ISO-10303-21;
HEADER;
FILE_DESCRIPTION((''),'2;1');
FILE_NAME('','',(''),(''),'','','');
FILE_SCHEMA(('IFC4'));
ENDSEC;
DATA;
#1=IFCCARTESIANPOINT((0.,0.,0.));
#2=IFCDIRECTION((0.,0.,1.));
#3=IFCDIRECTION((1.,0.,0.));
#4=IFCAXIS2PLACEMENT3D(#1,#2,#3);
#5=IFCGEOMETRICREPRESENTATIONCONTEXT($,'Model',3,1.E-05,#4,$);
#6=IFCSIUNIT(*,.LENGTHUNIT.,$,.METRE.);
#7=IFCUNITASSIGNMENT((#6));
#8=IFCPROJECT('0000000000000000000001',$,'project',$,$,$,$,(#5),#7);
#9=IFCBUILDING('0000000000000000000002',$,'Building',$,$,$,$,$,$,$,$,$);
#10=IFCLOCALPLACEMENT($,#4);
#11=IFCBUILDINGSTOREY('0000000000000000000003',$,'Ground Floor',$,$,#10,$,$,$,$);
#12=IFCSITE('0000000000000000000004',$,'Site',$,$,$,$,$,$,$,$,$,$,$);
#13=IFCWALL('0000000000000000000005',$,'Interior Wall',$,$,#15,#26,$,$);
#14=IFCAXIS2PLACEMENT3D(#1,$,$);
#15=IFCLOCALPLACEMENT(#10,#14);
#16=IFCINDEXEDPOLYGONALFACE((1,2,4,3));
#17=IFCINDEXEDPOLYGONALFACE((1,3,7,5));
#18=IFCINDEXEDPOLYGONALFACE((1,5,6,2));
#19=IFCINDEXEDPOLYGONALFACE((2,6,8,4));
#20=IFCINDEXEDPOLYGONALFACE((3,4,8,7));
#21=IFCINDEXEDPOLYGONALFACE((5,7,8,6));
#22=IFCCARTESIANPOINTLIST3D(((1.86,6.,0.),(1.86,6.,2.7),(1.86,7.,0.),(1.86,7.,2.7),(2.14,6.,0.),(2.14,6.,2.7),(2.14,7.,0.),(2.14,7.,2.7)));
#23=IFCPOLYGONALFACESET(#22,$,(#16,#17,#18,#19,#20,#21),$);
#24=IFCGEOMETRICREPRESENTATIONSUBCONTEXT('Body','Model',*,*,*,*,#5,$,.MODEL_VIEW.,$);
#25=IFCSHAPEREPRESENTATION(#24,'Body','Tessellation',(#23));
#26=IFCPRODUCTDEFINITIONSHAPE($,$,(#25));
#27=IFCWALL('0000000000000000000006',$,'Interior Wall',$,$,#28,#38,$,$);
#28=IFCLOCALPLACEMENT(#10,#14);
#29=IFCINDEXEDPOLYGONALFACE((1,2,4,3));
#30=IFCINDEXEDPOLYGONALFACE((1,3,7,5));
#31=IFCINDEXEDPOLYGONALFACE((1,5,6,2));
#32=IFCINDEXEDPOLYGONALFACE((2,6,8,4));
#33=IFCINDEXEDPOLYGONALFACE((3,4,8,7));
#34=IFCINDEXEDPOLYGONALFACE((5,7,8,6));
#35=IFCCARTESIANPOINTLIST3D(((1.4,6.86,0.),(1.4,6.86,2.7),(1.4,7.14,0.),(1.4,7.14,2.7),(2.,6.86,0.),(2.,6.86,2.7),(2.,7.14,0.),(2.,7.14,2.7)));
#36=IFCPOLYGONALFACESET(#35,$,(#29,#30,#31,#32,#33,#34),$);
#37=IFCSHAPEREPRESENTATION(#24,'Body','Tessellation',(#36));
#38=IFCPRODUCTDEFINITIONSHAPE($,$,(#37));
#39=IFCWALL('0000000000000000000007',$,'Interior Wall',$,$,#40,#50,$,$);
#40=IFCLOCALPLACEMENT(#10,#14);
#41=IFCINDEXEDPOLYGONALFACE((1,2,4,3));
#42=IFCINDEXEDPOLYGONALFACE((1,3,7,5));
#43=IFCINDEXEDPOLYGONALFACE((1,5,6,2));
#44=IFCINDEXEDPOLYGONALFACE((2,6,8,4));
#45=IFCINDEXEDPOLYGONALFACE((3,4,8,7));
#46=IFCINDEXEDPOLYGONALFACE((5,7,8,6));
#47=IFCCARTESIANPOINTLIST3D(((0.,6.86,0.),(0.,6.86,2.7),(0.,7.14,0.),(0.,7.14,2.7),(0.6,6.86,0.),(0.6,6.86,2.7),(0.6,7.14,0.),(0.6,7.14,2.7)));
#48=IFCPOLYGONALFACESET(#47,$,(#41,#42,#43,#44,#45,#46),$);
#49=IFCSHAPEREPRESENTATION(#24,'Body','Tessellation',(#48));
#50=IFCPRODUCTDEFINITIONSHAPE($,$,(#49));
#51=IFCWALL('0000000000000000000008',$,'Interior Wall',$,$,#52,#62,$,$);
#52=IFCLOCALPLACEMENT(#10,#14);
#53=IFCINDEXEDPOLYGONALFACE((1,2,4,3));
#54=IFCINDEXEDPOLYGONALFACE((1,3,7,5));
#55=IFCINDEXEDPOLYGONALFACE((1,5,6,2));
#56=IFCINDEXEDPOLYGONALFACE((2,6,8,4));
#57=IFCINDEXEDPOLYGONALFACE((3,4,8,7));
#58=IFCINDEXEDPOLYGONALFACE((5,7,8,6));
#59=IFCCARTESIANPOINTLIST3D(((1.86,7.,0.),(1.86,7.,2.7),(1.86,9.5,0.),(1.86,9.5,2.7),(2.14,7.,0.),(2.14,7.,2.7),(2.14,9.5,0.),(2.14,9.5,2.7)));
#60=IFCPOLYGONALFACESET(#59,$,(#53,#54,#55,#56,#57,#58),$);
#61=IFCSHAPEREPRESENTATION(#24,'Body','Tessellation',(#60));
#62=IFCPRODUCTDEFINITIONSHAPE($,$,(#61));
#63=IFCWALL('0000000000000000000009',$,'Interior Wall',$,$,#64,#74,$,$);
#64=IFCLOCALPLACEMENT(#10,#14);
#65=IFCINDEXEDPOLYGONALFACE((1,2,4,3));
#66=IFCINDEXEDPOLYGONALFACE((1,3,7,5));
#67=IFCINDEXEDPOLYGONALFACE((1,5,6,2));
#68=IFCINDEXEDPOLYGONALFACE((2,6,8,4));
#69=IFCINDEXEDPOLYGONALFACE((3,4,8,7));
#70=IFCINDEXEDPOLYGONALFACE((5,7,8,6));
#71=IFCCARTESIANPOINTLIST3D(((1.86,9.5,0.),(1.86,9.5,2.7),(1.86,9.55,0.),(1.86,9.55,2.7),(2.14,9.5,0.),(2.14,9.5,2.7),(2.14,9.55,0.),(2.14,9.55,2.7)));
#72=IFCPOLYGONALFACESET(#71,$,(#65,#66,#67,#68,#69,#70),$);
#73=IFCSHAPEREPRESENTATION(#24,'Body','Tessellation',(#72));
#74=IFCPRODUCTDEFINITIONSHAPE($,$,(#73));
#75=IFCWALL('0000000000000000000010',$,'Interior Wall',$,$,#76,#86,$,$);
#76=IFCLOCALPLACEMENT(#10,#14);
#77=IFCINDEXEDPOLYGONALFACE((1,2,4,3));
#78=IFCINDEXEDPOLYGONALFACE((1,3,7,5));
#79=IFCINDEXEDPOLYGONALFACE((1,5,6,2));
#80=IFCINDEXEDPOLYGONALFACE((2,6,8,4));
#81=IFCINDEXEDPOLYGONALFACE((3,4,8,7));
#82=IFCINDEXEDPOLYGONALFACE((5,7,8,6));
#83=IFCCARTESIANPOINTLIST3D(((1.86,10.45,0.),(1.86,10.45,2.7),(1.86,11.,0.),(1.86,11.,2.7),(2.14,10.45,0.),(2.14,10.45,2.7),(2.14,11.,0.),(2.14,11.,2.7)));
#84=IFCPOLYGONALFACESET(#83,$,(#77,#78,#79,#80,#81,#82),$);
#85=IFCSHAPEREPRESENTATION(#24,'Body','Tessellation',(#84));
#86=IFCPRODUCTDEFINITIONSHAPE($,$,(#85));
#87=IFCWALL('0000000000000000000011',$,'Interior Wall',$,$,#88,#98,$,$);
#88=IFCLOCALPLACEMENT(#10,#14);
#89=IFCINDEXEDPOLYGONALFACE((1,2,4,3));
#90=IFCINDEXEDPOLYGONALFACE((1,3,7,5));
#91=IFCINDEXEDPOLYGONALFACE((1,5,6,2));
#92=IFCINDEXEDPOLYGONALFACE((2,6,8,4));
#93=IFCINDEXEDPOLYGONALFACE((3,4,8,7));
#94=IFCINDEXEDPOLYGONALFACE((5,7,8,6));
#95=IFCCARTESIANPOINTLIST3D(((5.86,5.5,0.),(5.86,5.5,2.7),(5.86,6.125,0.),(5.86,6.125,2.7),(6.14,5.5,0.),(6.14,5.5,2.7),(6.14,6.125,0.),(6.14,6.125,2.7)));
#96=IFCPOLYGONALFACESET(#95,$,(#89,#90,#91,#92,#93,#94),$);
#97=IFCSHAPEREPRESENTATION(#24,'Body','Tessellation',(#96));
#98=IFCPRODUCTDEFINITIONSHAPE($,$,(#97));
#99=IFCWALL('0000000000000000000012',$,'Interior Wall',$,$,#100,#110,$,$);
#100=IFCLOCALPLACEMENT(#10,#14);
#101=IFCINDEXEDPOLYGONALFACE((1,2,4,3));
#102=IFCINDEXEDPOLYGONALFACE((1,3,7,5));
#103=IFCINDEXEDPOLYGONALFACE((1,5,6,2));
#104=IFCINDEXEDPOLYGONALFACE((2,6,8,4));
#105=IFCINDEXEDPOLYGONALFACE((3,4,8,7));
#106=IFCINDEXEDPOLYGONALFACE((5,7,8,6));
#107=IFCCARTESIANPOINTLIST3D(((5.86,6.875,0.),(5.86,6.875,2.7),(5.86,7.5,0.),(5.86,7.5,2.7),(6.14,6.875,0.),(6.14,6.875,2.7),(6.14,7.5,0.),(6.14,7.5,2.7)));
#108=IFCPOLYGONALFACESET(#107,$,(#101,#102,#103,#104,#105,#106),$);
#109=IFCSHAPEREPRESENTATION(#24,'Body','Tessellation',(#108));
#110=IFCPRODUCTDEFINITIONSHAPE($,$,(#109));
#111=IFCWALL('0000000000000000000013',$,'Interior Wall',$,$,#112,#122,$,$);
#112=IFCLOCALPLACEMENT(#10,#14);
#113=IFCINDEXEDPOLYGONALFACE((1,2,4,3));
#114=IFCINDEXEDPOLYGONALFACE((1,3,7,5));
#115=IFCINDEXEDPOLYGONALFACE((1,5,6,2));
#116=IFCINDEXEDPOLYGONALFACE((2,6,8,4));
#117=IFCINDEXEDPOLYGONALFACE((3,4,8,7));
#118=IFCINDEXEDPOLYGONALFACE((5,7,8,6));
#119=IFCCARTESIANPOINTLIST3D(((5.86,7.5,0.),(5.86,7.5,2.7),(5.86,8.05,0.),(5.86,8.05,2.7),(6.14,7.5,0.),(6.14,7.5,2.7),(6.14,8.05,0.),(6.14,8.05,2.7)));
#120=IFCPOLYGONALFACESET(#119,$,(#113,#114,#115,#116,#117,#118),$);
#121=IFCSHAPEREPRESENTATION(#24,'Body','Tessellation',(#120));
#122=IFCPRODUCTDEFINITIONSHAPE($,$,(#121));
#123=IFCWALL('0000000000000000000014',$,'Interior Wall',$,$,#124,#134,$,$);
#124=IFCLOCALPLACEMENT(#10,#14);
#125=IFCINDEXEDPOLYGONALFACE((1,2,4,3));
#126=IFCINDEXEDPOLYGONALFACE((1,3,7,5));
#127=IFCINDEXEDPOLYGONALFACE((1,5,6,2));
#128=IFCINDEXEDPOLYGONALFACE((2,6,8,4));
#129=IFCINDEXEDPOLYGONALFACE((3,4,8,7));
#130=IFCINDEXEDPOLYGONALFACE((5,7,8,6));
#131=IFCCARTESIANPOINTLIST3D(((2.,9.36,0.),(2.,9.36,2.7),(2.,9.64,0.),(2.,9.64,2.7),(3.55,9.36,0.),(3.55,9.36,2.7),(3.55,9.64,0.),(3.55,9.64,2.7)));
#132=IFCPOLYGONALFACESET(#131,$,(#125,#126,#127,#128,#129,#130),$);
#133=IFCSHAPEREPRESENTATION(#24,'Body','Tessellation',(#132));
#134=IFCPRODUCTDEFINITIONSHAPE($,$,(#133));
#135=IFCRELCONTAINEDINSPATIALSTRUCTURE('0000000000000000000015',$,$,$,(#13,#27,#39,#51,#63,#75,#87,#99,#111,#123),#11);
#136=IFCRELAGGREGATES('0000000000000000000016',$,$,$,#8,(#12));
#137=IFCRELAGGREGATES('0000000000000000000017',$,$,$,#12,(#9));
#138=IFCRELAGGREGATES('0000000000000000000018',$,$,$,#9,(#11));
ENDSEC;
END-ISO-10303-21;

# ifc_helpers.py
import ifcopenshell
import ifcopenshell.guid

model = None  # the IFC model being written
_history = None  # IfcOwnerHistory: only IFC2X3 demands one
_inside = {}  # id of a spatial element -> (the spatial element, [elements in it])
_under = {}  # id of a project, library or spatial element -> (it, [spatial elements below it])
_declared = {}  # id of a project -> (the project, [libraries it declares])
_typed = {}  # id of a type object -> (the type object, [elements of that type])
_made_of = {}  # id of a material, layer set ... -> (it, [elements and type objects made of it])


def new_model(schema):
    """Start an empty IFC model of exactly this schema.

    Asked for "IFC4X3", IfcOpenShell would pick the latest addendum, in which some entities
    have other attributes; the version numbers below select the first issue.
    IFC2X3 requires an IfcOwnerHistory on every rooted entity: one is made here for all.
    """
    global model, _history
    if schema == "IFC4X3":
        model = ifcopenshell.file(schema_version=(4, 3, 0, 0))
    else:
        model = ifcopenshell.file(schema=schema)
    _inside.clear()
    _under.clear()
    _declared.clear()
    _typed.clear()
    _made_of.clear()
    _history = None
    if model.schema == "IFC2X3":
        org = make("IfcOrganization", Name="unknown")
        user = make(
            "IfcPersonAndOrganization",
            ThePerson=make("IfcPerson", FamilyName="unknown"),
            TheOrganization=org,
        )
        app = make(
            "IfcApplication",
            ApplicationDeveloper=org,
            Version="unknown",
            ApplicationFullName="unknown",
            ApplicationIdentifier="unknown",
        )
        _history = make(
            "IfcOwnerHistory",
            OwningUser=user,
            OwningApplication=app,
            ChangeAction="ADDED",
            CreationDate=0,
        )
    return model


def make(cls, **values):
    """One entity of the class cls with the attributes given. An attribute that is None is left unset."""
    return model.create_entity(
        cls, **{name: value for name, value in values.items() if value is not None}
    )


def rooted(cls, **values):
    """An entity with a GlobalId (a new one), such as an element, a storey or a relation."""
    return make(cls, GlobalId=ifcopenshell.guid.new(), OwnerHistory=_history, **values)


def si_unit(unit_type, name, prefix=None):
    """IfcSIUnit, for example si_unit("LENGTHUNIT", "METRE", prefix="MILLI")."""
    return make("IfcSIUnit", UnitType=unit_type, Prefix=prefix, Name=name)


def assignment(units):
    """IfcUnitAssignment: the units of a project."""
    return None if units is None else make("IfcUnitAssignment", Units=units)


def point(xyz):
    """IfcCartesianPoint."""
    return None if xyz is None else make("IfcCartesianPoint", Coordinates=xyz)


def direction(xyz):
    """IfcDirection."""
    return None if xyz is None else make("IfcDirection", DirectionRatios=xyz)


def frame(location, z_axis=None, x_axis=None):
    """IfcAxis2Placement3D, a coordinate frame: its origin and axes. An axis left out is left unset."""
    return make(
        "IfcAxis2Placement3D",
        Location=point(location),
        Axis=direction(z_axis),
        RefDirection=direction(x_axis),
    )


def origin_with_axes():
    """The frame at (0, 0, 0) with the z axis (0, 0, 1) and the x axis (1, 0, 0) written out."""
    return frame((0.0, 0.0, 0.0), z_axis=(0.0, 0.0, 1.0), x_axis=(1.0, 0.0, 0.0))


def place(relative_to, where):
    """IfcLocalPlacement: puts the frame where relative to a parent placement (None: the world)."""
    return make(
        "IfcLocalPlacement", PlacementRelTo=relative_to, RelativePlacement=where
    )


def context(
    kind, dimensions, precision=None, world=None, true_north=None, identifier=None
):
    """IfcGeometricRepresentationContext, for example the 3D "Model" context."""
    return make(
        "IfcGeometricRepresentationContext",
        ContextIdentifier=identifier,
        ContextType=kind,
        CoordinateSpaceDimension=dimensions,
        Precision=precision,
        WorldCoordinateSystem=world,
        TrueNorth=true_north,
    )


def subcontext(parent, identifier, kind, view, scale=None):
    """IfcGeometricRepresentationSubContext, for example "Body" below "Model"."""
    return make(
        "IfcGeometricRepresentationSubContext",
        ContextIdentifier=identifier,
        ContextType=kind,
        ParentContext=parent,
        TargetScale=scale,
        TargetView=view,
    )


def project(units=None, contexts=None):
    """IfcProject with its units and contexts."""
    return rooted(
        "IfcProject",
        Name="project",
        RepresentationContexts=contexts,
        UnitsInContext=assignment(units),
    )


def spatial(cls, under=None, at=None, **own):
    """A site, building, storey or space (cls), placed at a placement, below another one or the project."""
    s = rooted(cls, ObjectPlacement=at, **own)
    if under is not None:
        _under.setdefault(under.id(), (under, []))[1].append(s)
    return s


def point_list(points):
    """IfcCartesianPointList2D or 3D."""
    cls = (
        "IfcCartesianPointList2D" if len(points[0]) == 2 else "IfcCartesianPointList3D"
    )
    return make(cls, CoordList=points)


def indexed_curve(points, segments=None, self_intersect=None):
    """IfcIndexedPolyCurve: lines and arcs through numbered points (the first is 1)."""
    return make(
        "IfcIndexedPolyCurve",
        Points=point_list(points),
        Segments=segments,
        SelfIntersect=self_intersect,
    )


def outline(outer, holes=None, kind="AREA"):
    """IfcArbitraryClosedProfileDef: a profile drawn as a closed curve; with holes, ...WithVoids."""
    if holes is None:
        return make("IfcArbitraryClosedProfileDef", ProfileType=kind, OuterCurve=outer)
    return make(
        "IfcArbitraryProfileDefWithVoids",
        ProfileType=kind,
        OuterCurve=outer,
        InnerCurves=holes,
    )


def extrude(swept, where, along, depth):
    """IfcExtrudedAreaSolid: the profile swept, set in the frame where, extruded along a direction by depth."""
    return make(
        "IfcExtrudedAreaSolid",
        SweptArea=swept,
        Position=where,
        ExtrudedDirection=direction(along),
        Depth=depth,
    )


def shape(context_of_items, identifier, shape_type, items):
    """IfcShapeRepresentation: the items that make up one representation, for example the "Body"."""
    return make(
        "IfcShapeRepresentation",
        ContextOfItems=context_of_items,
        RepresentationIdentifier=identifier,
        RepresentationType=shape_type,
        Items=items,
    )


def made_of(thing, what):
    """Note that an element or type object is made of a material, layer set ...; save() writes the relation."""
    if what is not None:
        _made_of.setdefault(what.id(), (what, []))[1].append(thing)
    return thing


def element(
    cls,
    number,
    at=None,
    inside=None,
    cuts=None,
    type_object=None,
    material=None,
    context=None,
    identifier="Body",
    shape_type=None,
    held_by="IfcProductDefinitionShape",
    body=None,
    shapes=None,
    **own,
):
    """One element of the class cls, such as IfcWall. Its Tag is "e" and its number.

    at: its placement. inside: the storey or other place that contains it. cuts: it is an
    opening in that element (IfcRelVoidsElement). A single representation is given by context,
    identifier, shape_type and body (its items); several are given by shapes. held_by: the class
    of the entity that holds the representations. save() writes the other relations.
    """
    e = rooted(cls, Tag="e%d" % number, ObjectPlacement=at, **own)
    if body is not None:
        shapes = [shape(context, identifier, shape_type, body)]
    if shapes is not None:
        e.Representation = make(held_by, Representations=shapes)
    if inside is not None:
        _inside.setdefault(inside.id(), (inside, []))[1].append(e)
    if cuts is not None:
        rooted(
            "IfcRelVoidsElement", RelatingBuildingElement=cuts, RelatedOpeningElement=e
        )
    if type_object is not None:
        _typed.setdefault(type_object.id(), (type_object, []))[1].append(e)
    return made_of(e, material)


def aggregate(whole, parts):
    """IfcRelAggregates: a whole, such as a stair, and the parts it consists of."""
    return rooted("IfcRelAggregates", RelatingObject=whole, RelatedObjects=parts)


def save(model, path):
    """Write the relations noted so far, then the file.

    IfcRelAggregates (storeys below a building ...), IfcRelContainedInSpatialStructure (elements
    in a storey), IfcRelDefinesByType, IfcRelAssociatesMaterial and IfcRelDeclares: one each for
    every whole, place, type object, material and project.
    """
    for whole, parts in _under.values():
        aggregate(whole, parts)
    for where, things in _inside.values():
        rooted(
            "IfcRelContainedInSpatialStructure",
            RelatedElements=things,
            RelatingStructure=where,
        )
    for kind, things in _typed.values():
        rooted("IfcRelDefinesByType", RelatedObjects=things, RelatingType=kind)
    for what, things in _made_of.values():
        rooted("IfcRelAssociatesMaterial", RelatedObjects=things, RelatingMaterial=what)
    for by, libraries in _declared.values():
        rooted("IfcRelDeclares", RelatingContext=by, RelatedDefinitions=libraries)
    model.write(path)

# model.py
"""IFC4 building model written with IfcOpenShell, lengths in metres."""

from ifc_helpers import new_model, si_unit, frame, origin_with_axes, place, context, subcontext, project, spatial, indexed_curve, outline, extrude, element, save


model = new_model("IFC4")

# Units and contexts
model_context = context("Model", 3, precision=1e-05, world=origin_with_axes())
body_context = subcontext(model_context, "Body", "Model", "MODEL_VIEW")
ifc_project = project(units=[si_unit("LENGTHUNIT", "METRE")], contexts=[model_context])

# Site, building, storey
site = spatial("IfcSite", under=ifc_project, Name="Site")
building = spatial("IfcBuilding", under=site, Name="Building")
storey_placement = place(None, origin_with_axes())
storey = spatial("IfcBuildingStorey", under=building, at=storey_placement, Name="Ground Floor")

# Walls
wall_1_placement = place(storey_placement, frame((2.0, 6.0, 0.0), z_axis=(0.0, 0.0, 1.0), x_axis=(0.0, 1.0, 0.0)))
element("IfcWall", 1, at=wall_1_placement, inside=storey, Name="Interior Wall", context=body_context, shape_type="SweptSolid", body=[
    extrude(outline(indexed_curve([(0.0, 0.0), (0.0, 0.28), (1.0, 0.28), (1.0, 0.0), (0.0, 0.0)], self_intersect=False)), frame((0.0, -0.14, 0.0), z_axis=(0.0, 0.0, 1.0), x_axis=(1.0, 0.0, 0.0)), (0.0, 0.0, 1.0), 2.7),
])
for number, where, z_axis, x_axis, name in (
    (2, (2.0, 7.0, 0.0), (0.0, 0.0, 1.0), (-1.0, 0.0, 0.0), "Interior Wall"),
    (3, (0.6, 7.0, 0.0), (0.0, 0.0, 1.0), (-1.0, 0.0, 0.0), "Interior Wall"),
):
    element("IfcWall", number, at=place(storey_placement, frame(where, z_axis=z_axis, x_axis=x_axis)), inside=storey, Name=name, context=body_context, shape_type="SweptSolid", body=[
        extrude(outline(indexed_curve([(0.0, 0.0), (0.0, 0.28), (0.6, 0.28), (0.6, 0.0), (0.0, 0.0)], self_intersect=False)), frame((0.0, -0.14, 0.0), z_axis=(0.0, 0.0, 1.0), x_axis=(1.0, 0.0, 0.0)), (0.0, 0.0, 1.0), 2.7),
    ])
wall_2_placement = place(storey_placement, frame((2.0, 7.0, 0.0), z_axis=(0.0, 0.0, 1.0), x_axis=(0.0, 1.0, 0.0)))
element("IfcWall", 4, at=wall_2_placement, inside=storey, Name="Interior Wall", context=body_context, shape_type="SweptSolid", body=[
    extrude(outline(indexed_curve([(0.0, 0.0), (0.0, 0.28), (2.5, 0.28), (2.5, 0.0), (0.0, 0.0)], self_intersect=False)), frame((0.0, -0.14, 0.0), z_axis=(0.0, 0.0, 1.0), x_axis=(1.0, 0.0, 0.0)), (0.0, 0.0, 1.0), 2.7),
])
wall_3_placement = place(storey_placement, frame((2.0, 9.5, 0.0), z_axis=(0.0, 0.0, 1.0), x_axis=(0.0, 1.0, 0.0)))
element("IfcWall", 5, at=wall_3_placement, inside=storey, Name="Interior Wall", context=body_context, shape_type="SweptSolid", body=[
    extrude(outline(indexed_curve([(0.0, 0.0), (0.0, 0.28), (0.05, 0.28), (0.05, 0.0), (0.0, 0.0)], self_intersect=False)), frame((0.0, -0.14, 0.0), z_axis=(0.0, 0.0, 1.0), x_axis=(1.0, 0.0, 0.0)), (0.0, 0.0, 1.0), 2.7),
])
wall_4_placement = place(storey_placement, frame((2.0, 10.45, 0.0), z_axis=(0.0, 0.0, 1.0), x_axis=(0.0, 1.0, 0.0)))
element("IfcWall", 6, at=wall_4_placement, inside=storey, Name="Interior Wall", context=body_context, shape_type="SweptSolid", body=[
    extrude(outline(indexed_curve([(0.0, 0.0), (0.0, 0.28), (0.55, 0.28), (0.55, 0.0), (0.0, 0.0)], self_intersect=False)), frame((0.0, -0.14, 0.0), z_axis=(0.0, 0.0, 1.0), x_axis=(1.0, 0.0, 0.0)), (0.0, 0.0, 1.0), 2.7),
])
for number, where, z_axis, x_axis, name in (
    (7, (6.0, 5.5, 0.0), (0.0, 0.0, 1.0), (0.0, 1.0, 0.0), "Interior Wall"),
    (8, (6.0, 6.875, 0.0), (0.0, 0.0, 1.0), (0.0, 1.0, 0.0), "Interior Wall"),
):
    element("IfcWall", number, at=place(storey_placement, frame(where, z_axis=z_axis, x_axis=x_axis)), inside=storey, Name=name, context=body_context, shape_type="SweptSolid", body=[
        extrude(outline(indexed_curve([(0.0, 0.0), (0.0, 0.28), (0.625, 0.28), (0.625, 0.0), (0.0, 0.0)], self_intersect=False)), frame((0.0, -0.14, 0.0), z_axis=(0.0, 0.0, 1.0), x_axis=(1.0, 0.0, 0.0)), (0.0, 0.0, 1.0), 2.7),
    ])
wall_5_placement = place(storey_placement, frame((6.0, 7.5, 0.0), z_axis=(0.0, 0.0, 1.0), x_axis=(0.0, 1.0, 0.0)))
element("IfcWall", 9, at=wall_5_placement, inside=storey, Name="Interior Wall", context=body_context, shape_type="SweptSolid", body=[
    extrude(outline(indexed_curve([(0.0, 0.0), (0.0, 0.28), (0.55, 0.28), (0.55, 0.0), (0.0, 0.0)], self_intersect=False)), frame((0.0, -0.14, 0.0), z_axis=(0.0, 0.0, 1.0), x_axis=(1.0, 0.0, 0.0)), (0.0, 0.0, 1.0), 2.7),
])
wall_6_placement = place(storey_placement, frame((3.55, 9.5, 0.0), z_axis=(0.0, 0.0, 1.0), x_axis=(-1.0, 0.0, 0.0)))
element("IfcWall", 10, at=wall_6_placement, inside=storey, Name="Interior Wall", context=body_context, shape_type="SweptSolid", body=[
    extrude(outline(indexed_curve([(0.0, 0.0), (0.0, 0.28), (1.55, 0.28), (1.55, 0.0), (0.0, 0.0)], self_intersect=False)), frame((0.0, -0.14, 0.0), z_axis=(0.0, 0.0, 1.0), x_axis=(1.0, 0.0, 0.0)), (0.0, 0.0, 1.0), 2.7),
])

save(model, "model.ifc")
